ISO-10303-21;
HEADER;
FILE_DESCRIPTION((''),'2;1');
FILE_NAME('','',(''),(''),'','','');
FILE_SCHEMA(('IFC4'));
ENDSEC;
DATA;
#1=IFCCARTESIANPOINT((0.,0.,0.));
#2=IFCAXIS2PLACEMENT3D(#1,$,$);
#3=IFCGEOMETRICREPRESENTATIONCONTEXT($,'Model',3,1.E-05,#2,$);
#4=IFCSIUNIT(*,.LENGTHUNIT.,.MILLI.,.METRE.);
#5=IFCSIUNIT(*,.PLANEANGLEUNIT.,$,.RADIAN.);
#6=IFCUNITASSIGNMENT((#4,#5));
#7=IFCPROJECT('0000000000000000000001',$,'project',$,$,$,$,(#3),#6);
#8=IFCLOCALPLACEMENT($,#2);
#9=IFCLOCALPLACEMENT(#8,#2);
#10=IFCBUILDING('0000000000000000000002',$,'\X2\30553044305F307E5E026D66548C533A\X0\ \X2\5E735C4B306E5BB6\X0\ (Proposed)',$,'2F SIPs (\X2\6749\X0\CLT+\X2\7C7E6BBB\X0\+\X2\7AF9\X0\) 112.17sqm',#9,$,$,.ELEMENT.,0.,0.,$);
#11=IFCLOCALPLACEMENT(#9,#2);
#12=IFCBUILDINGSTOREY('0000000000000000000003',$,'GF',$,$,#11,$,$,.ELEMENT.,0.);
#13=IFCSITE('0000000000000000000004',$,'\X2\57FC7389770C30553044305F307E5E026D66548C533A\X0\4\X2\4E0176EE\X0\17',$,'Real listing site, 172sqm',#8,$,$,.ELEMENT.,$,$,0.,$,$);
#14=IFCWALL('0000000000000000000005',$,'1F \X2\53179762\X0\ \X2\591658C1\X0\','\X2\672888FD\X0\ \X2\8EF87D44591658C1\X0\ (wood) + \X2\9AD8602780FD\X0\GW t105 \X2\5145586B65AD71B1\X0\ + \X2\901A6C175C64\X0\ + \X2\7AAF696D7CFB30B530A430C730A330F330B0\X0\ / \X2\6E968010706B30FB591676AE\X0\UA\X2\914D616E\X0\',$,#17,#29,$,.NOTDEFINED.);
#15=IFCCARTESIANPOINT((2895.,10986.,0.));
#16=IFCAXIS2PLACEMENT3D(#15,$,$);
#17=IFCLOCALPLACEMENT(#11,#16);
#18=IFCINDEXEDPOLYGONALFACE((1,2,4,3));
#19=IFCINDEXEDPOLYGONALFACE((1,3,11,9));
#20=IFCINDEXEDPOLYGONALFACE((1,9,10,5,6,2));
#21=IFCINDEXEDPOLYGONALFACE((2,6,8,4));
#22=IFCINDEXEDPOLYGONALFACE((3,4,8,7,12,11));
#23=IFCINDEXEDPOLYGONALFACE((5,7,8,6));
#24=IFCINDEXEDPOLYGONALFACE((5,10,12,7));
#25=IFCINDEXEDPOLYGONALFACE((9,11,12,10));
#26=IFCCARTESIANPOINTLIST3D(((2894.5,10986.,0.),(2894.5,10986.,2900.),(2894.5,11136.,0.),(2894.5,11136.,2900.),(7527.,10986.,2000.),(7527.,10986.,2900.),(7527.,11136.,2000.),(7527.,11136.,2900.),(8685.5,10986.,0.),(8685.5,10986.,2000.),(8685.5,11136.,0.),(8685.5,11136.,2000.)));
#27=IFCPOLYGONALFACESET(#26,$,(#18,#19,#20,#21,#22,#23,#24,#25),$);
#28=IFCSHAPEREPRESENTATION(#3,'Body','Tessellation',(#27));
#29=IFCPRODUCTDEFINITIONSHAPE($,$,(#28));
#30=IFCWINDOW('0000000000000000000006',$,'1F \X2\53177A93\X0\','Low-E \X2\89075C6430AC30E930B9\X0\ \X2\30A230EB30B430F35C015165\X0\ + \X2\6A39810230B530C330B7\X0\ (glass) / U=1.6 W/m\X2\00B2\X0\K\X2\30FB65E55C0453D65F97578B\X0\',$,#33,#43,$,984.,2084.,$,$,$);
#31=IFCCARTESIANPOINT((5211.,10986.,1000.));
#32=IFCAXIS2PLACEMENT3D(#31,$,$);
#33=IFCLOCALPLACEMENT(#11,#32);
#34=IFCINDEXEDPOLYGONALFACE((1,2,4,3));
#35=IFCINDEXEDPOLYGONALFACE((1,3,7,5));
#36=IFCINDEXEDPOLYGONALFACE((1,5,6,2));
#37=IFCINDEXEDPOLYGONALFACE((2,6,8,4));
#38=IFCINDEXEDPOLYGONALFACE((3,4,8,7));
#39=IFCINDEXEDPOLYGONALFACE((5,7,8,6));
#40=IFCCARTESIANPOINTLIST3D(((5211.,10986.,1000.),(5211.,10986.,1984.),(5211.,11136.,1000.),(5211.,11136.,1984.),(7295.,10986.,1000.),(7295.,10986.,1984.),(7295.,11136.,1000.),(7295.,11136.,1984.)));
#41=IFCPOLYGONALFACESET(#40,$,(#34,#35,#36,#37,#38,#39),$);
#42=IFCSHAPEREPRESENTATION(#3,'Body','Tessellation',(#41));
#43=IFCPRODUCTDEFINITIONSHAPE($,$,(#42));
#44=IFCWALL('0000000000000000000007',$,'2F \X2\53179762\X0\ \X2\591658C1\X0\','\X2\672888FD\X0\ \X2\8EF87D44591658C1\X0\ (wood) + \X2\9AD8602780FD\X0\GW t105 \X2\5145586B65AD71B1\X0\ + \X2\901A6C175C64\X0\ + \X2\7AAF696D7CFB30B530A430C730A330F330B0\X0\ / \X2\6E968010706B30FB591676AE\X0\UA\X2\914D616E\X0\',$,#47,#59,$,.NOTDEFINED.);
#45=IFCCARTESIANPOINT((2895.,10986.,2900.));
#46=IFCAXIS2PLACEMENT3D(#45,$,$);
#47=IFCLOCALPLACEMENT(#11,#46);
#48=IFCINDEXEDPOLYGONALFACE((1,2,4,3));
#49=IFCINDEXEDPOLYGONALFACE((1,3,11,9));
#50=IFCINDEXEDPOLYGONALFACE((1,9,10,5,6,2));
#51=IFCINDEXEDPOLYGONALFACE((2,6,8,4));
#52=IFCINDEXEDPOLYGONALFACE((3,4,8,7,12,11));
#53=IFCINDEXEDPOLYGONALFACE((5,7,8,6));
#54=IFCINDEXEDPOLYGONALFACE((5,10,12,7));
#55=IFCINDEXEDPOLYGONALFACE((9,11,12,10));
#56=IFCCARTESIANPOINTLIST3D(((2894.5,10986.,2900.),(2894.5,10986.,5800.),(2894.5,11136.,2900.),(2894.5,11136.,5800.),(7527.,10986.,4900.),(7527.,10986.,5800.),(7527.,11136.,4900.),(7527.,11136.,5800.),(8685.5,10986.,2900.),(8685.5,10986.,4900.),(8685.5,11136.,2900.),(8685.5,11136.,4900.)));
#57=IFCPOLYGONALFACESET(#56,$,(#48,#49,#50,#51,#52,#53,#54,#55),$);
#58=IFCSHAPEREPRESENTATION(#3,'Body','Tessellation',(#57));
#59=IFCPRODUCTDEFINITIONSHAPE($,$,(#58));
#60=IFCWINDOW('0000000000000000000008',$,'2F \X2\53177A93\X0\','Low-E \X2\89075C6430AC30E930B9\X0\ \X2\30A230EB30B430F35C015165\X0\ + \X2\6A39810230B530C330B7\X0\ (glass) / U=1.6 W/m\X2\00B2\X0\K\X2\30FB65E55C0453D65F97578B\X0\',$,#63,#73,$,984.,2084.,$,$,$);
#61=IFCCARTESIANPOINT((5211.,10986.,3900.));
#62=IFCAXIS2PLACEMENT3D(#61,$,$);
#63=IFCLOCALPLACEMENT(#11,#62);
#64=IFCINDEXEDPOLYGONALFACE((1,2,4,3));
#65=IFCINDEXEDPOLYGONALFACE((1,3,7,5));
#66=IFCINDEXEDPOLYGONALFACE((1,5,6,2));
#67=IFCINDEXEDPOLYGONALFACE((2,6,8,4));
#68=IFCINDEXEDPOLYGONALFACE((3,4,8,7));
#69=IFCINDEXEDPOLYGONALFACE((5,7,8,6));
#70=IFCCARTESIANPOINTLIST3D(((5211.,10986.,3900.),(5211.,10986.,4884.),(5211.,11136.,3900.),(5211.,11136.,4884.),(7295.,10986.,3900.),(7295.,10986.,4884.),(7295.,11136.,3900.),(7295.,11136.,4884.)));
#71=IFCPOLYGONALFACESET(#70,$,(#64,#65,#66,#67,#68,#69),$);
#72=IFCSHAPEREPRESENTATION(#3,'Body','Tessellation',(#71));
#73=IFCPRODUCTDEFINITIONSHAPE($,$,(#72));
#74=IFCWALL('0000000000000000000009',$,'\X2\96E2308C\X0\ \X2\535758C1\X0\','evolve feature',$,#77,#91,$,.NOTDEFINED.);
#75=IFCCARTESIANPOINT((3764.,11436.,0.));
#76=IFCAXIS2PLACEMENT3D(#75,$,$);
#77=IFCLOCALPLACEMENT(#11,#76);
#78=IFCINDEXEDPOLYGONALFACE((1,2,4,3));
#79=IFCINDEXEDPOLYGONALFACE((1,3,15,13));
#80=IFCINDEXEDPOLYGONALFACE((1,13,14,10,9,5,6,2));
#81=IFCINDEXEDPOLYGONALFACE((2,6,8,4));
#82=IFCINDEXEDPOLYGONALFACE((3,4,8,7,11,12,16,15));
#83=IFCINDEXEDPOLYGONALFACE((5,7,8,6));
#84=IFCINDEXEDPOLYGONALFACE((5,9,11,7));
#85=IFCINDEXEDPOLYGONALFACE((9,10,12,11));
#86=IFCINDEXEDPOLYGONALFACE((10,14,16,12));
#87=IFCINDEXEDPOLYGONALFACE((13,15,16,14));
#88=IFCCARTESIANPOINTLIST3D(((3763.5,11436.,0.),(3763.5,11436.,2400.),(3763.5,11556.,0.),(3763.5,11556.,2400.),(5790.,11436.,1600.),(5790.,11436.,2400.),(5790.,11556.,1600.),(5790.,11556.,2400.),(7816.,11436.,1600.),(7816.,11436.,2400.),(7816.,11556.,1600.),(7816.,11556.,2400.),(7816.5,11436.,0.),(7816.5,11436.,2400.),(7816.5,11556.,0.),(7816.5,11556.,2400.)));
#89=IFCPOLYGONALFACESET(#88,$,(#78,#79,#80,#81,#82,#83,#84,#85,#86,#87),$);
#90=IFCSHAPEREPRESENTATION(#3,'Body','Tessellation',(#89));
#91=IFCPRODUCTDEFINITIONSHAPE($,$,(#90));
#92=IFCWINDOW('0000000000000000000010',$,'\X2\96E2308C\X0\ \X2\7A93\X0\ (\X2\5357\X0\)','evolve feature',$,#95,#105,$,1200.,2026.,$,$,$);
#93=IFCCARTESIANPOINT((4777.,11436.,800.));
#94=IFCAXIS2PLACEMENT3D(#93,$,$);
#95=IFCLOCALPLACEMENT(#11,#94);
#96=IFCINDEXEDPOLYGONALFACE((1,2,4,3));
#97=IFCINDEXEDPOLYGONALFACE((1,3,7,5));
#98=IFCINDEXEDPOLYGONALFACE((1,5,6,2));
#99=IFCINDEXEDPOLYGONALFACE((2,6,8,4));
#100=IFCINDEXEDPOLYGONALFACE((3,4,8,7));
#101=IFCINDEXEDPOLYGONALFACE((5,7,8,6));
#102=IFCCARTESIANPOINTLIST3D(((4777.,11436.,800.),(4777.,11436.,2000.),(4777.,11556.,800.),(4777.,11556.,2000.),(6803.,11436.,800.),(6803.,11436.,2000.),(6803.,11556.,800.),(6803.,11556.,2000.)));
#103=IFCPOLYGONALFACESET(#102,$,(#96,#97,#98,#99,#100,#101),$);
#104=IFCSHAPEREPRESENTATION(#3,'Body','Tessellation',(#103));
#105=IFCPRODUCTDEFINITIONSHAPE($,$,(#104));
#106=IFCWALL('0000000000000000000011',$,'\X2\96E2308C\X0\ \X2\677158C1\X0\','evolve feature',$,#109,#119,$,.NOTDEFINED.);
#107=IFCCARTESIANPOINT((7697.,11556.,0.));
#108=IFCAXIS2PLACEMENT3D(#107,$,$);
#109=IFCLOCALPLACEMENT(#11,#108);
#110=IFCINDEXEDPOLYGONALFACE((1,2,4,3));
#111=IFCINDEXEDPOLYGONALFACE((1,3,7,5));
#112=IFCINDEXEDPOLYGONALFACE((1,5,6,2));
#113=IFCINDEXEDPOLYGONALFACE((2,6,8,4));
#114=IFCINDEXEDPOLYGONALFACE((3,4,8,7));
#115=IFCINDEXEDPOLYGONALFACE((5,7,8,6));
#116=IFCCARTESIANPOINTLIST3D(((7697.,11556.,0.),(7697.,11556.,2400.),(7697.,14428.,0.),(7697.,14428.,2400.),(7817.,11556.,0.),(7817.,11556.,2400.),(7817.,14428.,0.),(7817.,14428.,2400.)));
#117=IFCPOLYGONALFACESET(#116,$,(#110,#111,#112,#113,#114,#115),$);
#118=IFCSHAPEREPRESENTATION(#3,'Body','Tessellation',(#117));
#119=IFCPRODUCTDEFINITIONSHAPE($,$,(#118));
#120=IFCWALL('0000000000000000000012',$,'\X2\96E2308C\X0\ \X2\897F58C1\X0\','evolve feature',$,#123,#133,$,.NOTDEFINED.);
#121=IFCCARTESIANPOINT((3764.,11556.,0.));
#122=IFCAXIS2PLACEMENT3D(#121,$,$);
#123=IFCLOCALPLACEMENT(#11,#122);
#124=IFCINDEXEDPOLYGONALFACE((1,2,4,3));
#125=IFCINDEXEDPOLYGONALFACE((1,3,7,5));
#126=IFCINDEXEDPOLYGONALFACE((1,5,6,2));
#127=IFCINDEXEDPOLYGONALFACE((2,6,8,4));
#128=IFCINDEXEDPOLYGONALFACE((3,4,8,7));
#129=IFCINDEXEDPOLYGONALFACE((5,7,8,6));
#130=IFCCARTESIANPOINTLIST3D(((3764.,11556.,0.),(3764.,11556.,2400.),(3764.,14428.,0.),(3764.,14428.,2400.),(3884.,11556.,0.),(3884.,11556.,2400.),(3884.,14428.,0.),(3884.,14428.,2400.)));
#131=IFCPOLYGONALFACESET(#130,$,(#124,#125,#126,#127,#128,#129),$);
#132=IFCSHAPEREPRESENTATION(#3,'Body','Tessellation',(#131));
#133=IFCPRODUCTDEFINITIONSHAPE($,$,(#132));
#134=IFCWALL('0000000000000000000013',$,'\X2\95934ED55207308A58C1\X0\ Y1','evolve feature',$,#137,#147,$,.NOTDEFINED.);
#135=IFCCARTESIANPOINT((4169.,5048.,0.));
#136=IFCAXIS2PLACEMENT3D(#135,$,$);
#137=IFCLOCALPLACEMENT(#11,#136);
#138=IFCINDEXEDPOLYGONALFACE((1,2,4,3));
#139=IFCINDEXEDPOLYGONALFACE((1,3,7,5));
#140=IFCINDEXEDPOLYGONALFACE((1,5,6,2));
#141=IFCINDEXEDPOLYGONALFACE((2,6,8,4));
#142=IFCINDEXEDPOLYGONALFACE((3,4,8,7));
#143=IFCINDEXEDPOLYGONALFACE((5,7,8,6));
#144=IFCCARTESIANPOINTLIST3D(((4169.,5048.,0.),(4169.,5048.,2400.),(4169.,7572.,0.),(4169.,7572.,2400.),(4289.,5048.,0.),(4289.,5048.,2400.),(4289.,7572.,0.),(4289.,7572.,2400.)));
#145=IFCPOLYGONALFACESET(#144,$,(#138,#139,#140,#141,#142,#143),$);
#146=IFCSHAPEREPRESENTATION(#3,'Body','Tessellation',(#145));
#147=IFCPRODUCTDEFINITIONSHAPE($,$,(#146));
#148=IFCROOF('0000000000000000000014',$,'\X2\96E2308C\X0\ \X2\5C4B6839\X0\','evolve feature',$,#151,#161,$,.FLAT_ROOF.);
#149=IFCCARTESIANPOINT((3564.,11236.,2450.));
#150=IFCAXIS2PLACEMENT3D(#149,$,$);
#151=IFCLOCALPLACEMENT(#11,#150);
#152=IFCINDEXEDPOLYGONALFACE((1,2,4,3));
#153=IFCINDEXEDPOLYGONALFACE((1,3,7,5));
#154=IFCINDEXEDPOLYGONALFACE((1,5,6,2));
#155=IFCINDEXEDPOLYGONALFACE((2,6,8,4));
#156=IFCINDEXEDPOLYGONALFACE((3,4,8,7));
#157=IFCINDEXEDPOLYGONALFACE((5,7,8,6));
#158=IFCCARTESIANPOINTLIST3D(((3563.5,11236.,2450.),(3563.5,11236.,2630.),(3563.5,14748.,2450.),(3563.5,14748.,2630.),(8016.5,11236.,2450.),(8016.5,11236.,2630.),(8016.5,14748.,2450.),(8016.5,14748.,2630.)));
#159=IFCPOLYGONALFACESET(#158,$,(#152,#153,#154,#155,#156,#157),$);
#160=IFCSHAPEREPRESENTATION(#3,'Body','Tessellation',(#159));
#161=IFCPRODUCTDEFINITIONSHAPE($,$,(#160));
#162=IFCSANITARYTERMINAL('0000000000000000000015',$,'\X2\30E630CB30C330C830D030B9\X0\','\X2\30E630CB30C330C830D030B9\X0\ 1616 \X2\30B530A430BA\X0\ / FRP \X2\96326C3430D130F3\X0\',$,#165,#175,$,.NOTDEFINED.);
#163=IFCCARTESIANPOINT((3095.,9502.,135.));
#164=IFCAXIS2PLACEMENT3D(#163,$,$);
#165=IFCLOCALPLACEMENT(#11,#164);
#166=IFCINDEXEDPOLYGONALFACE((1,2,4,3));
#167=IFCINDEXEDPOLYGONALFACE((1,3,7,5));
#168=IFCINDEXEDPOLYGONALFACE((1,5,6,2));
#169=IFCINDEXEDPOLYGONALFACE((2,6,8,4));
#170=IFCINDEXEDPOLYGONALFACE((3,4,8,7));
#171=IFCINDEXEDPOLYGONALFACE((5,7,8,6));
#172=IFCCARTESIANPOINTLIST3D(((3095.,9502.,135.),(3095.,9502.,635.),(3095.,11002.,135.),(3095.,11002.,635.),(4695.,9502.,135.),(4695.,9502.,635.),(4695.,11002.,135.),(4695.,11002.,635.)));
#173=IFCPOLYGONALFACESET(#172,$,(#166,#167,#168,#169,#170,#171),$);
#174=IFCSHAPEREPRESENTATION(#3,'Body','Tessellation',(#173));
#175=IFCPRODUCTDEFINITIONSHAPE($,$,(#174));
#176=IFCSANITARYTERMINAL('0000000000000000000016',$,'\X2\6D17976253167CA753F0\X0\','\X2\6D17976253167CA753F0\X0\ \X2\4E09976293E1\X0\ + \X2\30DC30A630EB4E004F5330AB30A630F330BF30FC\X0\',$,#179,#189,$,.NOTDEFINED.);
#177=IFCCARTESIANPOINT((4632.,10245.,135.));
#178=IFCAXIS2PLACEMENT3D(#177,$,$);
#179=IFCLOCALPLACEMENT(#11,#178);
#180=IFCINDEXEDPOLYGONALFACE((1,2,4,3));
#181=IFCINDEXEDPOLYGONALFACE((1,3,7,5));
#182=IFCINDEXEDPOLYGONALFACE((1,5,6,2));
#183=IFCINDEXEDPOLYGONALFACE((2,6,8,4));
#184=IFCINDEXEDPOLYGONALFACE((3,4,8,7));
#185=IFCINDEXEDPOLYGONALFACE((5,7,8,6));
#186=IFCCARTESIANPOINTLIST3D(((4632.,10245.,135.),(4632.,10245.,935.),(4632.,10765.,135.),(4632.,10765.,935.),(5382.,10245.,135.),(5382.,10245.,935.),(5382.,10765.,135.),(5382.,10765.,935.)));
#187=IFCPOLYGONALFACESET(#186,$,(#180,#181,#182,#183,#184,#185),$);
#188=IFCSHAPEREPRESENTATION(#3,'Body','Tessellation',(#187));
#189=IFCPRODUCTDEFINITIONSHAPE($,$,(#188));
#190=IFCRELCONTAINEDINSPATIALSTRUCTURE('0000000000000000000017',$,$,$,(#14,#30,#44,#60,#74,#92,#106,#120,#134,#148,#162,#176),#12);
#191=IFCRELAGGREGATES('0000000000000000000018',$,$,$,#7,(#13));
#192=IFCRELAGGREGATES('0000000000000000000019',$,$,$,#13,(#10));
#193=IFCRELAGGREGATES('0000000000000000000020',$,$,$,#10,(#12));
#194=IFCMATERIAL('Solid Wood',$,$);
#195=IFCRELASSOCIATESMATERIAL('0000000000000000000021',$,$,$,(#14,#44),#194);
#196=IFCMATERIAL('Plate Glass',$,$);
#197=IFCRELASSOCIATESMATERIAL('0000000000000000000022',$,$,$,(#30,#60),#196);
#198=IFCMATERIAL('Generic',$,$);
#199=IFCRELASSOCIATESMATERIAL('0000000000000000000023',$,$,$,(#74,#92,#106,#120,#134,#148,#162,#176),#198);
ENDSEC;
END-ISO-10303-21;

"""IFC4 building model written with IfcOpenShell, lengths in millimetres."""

from ifc_helpers import new_model, si_unit, frame, frame_2d, origin, place, context, project, spatial, rectangle, extrude, material, element, fill, save


model = new_model("IFC4")

# Units and contexts
model_context = context("Model", 3, precision=1e-05, world=origin())
ifc_project = project(units=[si_unit("LENGTHUNIT", "METRE", prefix="MILLI"), si_unit("PLANEANGLEUNIT", "RADIAN")], contexts=[model_context])

# Site, building, storey
site_placement = place(None, origin())
site = spatial("IfcSite", under=ifc_project, at=site_placement, Name="埼玉県さいたま市浦和区4丁目17", ObjectType="Real listing site, 172sqm", CompositionType="ELEMENT", RefElevation=0.0)
building_placement = place(site_placement, origin())
building = spatial("IfcBuilding", under=site, at=building_placement, Name="さいたま市浦和区 平屋の家 (Proposed)", ObjectType="2F SIPs (杉CLT+籾殻+竹) 112.17sqm", CompositionType="ELEMENT", ElevationOfRefHeight=0.0, ElevationOfTerrain=0.0)
storey_placement = place(building_placement, origin())
storey = spatial("IfcBuildingStorey", under=building, at=storey_placement, Name="GF", CompositionType="ELEMENT", Elevation=0.0)

# Shared definitions
ifc_material_1 = material(Name="Generic")

# Wall, opening, window
ifc_material_2 = material(Name="Solid Wood")
wall_1_placement = place(storey_placement, frame((2895.0, 10986.0, 0.0)))
wall_1 = element("IfcWall", 1, at=wall_1_placement, inside=storey, material=ifc_material_2, Name="1F 北面 外壁", Description="木製 軸組外壁 (wood) + 高性能GW t105 充填断熱 + 通気層 + 窯業系サイディング / 準耐火・外皮UA配慮", PredefinedType="NOTDEFINED", context=model_context, shape_type="SweptSolid", body=[
    extrude(rectangle(XDim=5791.0, YDim=150.0, at=frame_2d((2895.0, 75.0))), frame((2895.0, 10986.0, 0.0)), (0.0, 0.0, 1.0), 2900.0),
])
opening_1_placement = place(storey_placement, frame((5211.0, 10986.0, 1000.0)))
opening_1 = element("IfcOpeningElement", 2, at=opening_1_placement, cuts=wall_1, PredefinedType="NOTDEFINED", context=model_context, shape_type="SweptSolid", body=[
    extrude(rectangle(XDim=2084.0, YDim=150.0, at=frame_2d((1042.0, 75.0))), frame((5211.0, 10986.0, 1000.0)), (0.0, 0.0, 1.0), 984.0),
])
ifc_material_3 = material(Name="Plate Glass")
window_1_placement = place(storey_placement, frame((5211.0, 10986.0, 1000.0)))
window_1 = element("IfcWindow", 3, at=window_1_placement, inside=storey, material=ifc_material_3, Name="1F 北窓", Description="Low-E 複層ガラス アルゴン封入 + 樹脂サッシ (glass) / U=1.6 W/m²K・日射取得型", OverallHeight=984.0, OverallWidth=2084.0, context=model_context, shape_type="SweptSolid", body=[
    extrude(rectangle(XDim=2084.0, YDim=150.0, at=frame_2d((1042.0, 75.0))), frame((5211.0, 10986.0, 1000.0)), (0.0, 0.0, 1.0), 984.0),
])
fill(opening_1, window_1)

# Wall, opening, window
wall_2_placement = place(storey_placement, frame((2895.0, 10986.0, 2900.0)))
wall_2 = element("IfcWall", 4, at=wall_2_placement, inside=storey, material=ifc_material_2, Name="2F 北面 外壁", Description="木製 軸組外壁 (wood) + 高性能GW t105 充填断熱 + 通気層 + 窯業系サイディング / 準耐火・外皮UA配慮", PredefinedType="NOTDEFINED", context=model_context, shape_type="SweptSolid", body=[
    extrude(rectangle(XDim=5791.0, YDim=150.0, at=frame_2d((2895.0, 75.0))), frame((2895.0, 10986.0, 2900.0)), (0.0, 0.0, 1.0), 2900.0),
])
opening_2_placement = place(storey_placement, frame((5211.0, 10986.0, 3900.0)))
opening_2 = element("IfcOpeningElement", 5, at=opening_2_placement, cuts=wall_2, PredefinedType="NOTDEFINED", context=model_context, shape_type="SweptSolid", body=[
    extrude(rectangle(XDim=2084.0, YDim=150.0, at=frame_2d((1042.0, 75.0))), frame((5211.0, 10986.0, 3900.0)), (0.0, 0.0, 1.0), 984.0),
])
window_2_placement = place(storey_placement, frame((5211.0, 10986.0, 3900.0)))
window_2 = element("IfcWindow", 6, at=window_2_placement, inside=storey, material=ifc_material_3, Name="2F 北窓", Description="Low-E 複層ガラス アルゴン封入 + 樹脂サッシ (glass) / U=1.6 W/m²K・日射取得型", OverallHeight=984.0, OverallWidth=2084.0, context=model_context, shape_type="SweptSolid", body=[
    extrude(rectangle(XDim=2084.0, YDim=150.0, at=frame_2d((1042.0, 75.0))), frame((5211.0, 10986.0, 3900.0)), (0.0, 0.0, 1.0), 984.0),
])
fill(opening_2, window_2)

# Wall, opening, window
wall_3_placement = place(storey_placement, frame((3764.0, 11436.0, 0.0)))
wall_3 = element("IfcWall", 7, at=wall_3_placement, inside=storey, material=ifc_material_1, Name="離れ 南壁", Description="evolve feature", PredefinedType="NOTDEFINED", context=model_context, shape_type="SweptSolid", body=[
    extrude(rectangle(XDim=4053.0, YDim=120.0, at=frame_2d((2026.0, 60.0))), frame((3764.0, 11436.0, 0.0)), (0.0, 0.0, 1.0), 2400.0),
])
opening_3_placement = place(storey_placement, frame((4777.0, 11436.0, 800.0)))
opening_3 = element("IfcOpeningElement", 8, at=opening_3_placement, cuts=wall_3, PredefinedType="NOTDEFINED", context=model_context, shape_type="SweptSolid", body=[
    extrude(rectangle(XDim=2026.0, YDim=120.0, at=frame_2d((1013.0, 60.0))), frame((4777.0, 11436.0, 800.0)), (0.0, 0.0, 1.0), 1200.0),
])
window_3_placement = place(storey_placement, frame((4777.0, 11436.0, 800.0)))
window_3 = element("IfcWindow", 9, at=window_3_placement, inside=storey, material=ifc_material_1, Name="離れ 窓 (南)", Description="evolve feature", OverallHeight=1200.0, OverallWidth=2026.0, context=model_context, shape_type="SweptSolid", body=[
    extrude(rectangle(XDim=2026.0, YDim=120.0, at=frame_2d((1013.0, 60.0))), frame((4777.0, 11436.0, 800.0)), (0.0, 0.0, 1.0), 1200.0),
])
fill(opening_3, window_3)

# Walls
wall_4_placement = place(storey_placement, frame((7697.0, 11556.0, 0.0)))
element("IfcWall", 10, at=wall_4_placement, inside=storey, material=ifc_material_1, Name="離れ 東壁", Description="evolve feature", PredefinedType="NOTDEFINED", context=model_context, shape_type="SweptSolid", body=[
    extrude(rectangle(XDim=120.0, YDim=2872.0, at=frame_2d((60.0, 1436.0))), frame((7697.0, 11556.0, 0.0)), (0.0, 0.0, 1.0), 2400.0),
])
wall_5_placement = place(storey_placement, frame((3764.0, 11556.0, 0.0)))
element("IfcWall", 11, at=wall_5_placement, inside=storey, material=ifc_material_1, Name="離れ 西壁", Description="evolve feature", PredefinedType="NOTDEFINED", context=model_context, shape_type="SweptSolid", body=[
    extrude(rectangle(XDim=120.0, YDim=2872.0, at=frame_2d((60.0, 1436.0))), frame((3764.0, 11556.0, 0.0)), (0.0, 0.0, 1.0), 2400.0),
])
wall_6_placement = place(storey_placement, frame((4169.0, 5048.0, 0.0)))
element("IfcWall", 12, at=wall_6_placement, inside=storey, material=ifc_material_1, Name="間仕切り壁 Y1", Description="evolve feature", PredefinedType="NOTDEFINED", context=model_context, shape_type="SweptSolid", body=[
    extrude(rectangle(XDim=120.0, YDim=2524.0, at=frame_2d((60.0, 1262.0))), frame((4169.0, 5048.0, 0.0)), (0.0, 0.0, 1.0), 2400.0),
])

# Roof
roof_1_placement = place(storey_placement, frame((3564.0, 11236.0, 2450.0)))
element("IfcRoof", 13, at=roof_1_placement, inside=storey, material=ifc_material_1, Name="離れ 屋根", Description="evolve feature", PredefinedType="FLAT_ROOF", context=model_context, shape_type="SweptSolid", body=[
    extrude(rectangle(XDim=4453.0, YDim=3512.0, at=frame_2d((2226.0, 1756.0))), frame((3564.0, 11236.0, 2450.0)), (0.0, 0.0, 1.0), 180.0),
])

# Sanitary terminals
sanitary_terminal_1_placement = place(storey_placement, frame((3095.0, 9502.0, 135.0)))
element("IfcSanitaryTerminal", 14, at=sanitary_terminal_1_placement, inside=storey, material=ifc_material_1, Name="ユニットバス", Description="ユニットバス 1616 サイズ / FRP 防水パン", PredefinedType="NOTDEFINED", context=model_context, shape_type="SweptSolid", body=[
    extrude(rectangle(XDim=1600.0, YDim=1500.0, at=frame_2d((800.0, 750.0))), frame((3095.0, 9502.0, 135.0)), (0.0, 0.0, 1.0), 500.0),
])
sanitary_terminal_2_placement = place(storey_placement, frame((4632.0, 10245.0, 135.0)))
element("IfcSanitaryTerminal", 15, at=sanitary_terminal_2_placement, inside=storey, material=ifc_material_1, Name="洗面化粧台", Description="洗面化粧台 三面鏡 + ボウル一体カウンター", PredefinedType="NOTDEFINED", context=model_context, shape_type="SweptSolid", body=[
    extrude(rectangle(XDim=750.0, YDim=520.0, at=frame_2d((375.0, 260.0))), frame((4632.0, 10245.0, 135.0)), (0.0, 0.0, 1.0), 800.0),
])

save(model, "model.ifc")
